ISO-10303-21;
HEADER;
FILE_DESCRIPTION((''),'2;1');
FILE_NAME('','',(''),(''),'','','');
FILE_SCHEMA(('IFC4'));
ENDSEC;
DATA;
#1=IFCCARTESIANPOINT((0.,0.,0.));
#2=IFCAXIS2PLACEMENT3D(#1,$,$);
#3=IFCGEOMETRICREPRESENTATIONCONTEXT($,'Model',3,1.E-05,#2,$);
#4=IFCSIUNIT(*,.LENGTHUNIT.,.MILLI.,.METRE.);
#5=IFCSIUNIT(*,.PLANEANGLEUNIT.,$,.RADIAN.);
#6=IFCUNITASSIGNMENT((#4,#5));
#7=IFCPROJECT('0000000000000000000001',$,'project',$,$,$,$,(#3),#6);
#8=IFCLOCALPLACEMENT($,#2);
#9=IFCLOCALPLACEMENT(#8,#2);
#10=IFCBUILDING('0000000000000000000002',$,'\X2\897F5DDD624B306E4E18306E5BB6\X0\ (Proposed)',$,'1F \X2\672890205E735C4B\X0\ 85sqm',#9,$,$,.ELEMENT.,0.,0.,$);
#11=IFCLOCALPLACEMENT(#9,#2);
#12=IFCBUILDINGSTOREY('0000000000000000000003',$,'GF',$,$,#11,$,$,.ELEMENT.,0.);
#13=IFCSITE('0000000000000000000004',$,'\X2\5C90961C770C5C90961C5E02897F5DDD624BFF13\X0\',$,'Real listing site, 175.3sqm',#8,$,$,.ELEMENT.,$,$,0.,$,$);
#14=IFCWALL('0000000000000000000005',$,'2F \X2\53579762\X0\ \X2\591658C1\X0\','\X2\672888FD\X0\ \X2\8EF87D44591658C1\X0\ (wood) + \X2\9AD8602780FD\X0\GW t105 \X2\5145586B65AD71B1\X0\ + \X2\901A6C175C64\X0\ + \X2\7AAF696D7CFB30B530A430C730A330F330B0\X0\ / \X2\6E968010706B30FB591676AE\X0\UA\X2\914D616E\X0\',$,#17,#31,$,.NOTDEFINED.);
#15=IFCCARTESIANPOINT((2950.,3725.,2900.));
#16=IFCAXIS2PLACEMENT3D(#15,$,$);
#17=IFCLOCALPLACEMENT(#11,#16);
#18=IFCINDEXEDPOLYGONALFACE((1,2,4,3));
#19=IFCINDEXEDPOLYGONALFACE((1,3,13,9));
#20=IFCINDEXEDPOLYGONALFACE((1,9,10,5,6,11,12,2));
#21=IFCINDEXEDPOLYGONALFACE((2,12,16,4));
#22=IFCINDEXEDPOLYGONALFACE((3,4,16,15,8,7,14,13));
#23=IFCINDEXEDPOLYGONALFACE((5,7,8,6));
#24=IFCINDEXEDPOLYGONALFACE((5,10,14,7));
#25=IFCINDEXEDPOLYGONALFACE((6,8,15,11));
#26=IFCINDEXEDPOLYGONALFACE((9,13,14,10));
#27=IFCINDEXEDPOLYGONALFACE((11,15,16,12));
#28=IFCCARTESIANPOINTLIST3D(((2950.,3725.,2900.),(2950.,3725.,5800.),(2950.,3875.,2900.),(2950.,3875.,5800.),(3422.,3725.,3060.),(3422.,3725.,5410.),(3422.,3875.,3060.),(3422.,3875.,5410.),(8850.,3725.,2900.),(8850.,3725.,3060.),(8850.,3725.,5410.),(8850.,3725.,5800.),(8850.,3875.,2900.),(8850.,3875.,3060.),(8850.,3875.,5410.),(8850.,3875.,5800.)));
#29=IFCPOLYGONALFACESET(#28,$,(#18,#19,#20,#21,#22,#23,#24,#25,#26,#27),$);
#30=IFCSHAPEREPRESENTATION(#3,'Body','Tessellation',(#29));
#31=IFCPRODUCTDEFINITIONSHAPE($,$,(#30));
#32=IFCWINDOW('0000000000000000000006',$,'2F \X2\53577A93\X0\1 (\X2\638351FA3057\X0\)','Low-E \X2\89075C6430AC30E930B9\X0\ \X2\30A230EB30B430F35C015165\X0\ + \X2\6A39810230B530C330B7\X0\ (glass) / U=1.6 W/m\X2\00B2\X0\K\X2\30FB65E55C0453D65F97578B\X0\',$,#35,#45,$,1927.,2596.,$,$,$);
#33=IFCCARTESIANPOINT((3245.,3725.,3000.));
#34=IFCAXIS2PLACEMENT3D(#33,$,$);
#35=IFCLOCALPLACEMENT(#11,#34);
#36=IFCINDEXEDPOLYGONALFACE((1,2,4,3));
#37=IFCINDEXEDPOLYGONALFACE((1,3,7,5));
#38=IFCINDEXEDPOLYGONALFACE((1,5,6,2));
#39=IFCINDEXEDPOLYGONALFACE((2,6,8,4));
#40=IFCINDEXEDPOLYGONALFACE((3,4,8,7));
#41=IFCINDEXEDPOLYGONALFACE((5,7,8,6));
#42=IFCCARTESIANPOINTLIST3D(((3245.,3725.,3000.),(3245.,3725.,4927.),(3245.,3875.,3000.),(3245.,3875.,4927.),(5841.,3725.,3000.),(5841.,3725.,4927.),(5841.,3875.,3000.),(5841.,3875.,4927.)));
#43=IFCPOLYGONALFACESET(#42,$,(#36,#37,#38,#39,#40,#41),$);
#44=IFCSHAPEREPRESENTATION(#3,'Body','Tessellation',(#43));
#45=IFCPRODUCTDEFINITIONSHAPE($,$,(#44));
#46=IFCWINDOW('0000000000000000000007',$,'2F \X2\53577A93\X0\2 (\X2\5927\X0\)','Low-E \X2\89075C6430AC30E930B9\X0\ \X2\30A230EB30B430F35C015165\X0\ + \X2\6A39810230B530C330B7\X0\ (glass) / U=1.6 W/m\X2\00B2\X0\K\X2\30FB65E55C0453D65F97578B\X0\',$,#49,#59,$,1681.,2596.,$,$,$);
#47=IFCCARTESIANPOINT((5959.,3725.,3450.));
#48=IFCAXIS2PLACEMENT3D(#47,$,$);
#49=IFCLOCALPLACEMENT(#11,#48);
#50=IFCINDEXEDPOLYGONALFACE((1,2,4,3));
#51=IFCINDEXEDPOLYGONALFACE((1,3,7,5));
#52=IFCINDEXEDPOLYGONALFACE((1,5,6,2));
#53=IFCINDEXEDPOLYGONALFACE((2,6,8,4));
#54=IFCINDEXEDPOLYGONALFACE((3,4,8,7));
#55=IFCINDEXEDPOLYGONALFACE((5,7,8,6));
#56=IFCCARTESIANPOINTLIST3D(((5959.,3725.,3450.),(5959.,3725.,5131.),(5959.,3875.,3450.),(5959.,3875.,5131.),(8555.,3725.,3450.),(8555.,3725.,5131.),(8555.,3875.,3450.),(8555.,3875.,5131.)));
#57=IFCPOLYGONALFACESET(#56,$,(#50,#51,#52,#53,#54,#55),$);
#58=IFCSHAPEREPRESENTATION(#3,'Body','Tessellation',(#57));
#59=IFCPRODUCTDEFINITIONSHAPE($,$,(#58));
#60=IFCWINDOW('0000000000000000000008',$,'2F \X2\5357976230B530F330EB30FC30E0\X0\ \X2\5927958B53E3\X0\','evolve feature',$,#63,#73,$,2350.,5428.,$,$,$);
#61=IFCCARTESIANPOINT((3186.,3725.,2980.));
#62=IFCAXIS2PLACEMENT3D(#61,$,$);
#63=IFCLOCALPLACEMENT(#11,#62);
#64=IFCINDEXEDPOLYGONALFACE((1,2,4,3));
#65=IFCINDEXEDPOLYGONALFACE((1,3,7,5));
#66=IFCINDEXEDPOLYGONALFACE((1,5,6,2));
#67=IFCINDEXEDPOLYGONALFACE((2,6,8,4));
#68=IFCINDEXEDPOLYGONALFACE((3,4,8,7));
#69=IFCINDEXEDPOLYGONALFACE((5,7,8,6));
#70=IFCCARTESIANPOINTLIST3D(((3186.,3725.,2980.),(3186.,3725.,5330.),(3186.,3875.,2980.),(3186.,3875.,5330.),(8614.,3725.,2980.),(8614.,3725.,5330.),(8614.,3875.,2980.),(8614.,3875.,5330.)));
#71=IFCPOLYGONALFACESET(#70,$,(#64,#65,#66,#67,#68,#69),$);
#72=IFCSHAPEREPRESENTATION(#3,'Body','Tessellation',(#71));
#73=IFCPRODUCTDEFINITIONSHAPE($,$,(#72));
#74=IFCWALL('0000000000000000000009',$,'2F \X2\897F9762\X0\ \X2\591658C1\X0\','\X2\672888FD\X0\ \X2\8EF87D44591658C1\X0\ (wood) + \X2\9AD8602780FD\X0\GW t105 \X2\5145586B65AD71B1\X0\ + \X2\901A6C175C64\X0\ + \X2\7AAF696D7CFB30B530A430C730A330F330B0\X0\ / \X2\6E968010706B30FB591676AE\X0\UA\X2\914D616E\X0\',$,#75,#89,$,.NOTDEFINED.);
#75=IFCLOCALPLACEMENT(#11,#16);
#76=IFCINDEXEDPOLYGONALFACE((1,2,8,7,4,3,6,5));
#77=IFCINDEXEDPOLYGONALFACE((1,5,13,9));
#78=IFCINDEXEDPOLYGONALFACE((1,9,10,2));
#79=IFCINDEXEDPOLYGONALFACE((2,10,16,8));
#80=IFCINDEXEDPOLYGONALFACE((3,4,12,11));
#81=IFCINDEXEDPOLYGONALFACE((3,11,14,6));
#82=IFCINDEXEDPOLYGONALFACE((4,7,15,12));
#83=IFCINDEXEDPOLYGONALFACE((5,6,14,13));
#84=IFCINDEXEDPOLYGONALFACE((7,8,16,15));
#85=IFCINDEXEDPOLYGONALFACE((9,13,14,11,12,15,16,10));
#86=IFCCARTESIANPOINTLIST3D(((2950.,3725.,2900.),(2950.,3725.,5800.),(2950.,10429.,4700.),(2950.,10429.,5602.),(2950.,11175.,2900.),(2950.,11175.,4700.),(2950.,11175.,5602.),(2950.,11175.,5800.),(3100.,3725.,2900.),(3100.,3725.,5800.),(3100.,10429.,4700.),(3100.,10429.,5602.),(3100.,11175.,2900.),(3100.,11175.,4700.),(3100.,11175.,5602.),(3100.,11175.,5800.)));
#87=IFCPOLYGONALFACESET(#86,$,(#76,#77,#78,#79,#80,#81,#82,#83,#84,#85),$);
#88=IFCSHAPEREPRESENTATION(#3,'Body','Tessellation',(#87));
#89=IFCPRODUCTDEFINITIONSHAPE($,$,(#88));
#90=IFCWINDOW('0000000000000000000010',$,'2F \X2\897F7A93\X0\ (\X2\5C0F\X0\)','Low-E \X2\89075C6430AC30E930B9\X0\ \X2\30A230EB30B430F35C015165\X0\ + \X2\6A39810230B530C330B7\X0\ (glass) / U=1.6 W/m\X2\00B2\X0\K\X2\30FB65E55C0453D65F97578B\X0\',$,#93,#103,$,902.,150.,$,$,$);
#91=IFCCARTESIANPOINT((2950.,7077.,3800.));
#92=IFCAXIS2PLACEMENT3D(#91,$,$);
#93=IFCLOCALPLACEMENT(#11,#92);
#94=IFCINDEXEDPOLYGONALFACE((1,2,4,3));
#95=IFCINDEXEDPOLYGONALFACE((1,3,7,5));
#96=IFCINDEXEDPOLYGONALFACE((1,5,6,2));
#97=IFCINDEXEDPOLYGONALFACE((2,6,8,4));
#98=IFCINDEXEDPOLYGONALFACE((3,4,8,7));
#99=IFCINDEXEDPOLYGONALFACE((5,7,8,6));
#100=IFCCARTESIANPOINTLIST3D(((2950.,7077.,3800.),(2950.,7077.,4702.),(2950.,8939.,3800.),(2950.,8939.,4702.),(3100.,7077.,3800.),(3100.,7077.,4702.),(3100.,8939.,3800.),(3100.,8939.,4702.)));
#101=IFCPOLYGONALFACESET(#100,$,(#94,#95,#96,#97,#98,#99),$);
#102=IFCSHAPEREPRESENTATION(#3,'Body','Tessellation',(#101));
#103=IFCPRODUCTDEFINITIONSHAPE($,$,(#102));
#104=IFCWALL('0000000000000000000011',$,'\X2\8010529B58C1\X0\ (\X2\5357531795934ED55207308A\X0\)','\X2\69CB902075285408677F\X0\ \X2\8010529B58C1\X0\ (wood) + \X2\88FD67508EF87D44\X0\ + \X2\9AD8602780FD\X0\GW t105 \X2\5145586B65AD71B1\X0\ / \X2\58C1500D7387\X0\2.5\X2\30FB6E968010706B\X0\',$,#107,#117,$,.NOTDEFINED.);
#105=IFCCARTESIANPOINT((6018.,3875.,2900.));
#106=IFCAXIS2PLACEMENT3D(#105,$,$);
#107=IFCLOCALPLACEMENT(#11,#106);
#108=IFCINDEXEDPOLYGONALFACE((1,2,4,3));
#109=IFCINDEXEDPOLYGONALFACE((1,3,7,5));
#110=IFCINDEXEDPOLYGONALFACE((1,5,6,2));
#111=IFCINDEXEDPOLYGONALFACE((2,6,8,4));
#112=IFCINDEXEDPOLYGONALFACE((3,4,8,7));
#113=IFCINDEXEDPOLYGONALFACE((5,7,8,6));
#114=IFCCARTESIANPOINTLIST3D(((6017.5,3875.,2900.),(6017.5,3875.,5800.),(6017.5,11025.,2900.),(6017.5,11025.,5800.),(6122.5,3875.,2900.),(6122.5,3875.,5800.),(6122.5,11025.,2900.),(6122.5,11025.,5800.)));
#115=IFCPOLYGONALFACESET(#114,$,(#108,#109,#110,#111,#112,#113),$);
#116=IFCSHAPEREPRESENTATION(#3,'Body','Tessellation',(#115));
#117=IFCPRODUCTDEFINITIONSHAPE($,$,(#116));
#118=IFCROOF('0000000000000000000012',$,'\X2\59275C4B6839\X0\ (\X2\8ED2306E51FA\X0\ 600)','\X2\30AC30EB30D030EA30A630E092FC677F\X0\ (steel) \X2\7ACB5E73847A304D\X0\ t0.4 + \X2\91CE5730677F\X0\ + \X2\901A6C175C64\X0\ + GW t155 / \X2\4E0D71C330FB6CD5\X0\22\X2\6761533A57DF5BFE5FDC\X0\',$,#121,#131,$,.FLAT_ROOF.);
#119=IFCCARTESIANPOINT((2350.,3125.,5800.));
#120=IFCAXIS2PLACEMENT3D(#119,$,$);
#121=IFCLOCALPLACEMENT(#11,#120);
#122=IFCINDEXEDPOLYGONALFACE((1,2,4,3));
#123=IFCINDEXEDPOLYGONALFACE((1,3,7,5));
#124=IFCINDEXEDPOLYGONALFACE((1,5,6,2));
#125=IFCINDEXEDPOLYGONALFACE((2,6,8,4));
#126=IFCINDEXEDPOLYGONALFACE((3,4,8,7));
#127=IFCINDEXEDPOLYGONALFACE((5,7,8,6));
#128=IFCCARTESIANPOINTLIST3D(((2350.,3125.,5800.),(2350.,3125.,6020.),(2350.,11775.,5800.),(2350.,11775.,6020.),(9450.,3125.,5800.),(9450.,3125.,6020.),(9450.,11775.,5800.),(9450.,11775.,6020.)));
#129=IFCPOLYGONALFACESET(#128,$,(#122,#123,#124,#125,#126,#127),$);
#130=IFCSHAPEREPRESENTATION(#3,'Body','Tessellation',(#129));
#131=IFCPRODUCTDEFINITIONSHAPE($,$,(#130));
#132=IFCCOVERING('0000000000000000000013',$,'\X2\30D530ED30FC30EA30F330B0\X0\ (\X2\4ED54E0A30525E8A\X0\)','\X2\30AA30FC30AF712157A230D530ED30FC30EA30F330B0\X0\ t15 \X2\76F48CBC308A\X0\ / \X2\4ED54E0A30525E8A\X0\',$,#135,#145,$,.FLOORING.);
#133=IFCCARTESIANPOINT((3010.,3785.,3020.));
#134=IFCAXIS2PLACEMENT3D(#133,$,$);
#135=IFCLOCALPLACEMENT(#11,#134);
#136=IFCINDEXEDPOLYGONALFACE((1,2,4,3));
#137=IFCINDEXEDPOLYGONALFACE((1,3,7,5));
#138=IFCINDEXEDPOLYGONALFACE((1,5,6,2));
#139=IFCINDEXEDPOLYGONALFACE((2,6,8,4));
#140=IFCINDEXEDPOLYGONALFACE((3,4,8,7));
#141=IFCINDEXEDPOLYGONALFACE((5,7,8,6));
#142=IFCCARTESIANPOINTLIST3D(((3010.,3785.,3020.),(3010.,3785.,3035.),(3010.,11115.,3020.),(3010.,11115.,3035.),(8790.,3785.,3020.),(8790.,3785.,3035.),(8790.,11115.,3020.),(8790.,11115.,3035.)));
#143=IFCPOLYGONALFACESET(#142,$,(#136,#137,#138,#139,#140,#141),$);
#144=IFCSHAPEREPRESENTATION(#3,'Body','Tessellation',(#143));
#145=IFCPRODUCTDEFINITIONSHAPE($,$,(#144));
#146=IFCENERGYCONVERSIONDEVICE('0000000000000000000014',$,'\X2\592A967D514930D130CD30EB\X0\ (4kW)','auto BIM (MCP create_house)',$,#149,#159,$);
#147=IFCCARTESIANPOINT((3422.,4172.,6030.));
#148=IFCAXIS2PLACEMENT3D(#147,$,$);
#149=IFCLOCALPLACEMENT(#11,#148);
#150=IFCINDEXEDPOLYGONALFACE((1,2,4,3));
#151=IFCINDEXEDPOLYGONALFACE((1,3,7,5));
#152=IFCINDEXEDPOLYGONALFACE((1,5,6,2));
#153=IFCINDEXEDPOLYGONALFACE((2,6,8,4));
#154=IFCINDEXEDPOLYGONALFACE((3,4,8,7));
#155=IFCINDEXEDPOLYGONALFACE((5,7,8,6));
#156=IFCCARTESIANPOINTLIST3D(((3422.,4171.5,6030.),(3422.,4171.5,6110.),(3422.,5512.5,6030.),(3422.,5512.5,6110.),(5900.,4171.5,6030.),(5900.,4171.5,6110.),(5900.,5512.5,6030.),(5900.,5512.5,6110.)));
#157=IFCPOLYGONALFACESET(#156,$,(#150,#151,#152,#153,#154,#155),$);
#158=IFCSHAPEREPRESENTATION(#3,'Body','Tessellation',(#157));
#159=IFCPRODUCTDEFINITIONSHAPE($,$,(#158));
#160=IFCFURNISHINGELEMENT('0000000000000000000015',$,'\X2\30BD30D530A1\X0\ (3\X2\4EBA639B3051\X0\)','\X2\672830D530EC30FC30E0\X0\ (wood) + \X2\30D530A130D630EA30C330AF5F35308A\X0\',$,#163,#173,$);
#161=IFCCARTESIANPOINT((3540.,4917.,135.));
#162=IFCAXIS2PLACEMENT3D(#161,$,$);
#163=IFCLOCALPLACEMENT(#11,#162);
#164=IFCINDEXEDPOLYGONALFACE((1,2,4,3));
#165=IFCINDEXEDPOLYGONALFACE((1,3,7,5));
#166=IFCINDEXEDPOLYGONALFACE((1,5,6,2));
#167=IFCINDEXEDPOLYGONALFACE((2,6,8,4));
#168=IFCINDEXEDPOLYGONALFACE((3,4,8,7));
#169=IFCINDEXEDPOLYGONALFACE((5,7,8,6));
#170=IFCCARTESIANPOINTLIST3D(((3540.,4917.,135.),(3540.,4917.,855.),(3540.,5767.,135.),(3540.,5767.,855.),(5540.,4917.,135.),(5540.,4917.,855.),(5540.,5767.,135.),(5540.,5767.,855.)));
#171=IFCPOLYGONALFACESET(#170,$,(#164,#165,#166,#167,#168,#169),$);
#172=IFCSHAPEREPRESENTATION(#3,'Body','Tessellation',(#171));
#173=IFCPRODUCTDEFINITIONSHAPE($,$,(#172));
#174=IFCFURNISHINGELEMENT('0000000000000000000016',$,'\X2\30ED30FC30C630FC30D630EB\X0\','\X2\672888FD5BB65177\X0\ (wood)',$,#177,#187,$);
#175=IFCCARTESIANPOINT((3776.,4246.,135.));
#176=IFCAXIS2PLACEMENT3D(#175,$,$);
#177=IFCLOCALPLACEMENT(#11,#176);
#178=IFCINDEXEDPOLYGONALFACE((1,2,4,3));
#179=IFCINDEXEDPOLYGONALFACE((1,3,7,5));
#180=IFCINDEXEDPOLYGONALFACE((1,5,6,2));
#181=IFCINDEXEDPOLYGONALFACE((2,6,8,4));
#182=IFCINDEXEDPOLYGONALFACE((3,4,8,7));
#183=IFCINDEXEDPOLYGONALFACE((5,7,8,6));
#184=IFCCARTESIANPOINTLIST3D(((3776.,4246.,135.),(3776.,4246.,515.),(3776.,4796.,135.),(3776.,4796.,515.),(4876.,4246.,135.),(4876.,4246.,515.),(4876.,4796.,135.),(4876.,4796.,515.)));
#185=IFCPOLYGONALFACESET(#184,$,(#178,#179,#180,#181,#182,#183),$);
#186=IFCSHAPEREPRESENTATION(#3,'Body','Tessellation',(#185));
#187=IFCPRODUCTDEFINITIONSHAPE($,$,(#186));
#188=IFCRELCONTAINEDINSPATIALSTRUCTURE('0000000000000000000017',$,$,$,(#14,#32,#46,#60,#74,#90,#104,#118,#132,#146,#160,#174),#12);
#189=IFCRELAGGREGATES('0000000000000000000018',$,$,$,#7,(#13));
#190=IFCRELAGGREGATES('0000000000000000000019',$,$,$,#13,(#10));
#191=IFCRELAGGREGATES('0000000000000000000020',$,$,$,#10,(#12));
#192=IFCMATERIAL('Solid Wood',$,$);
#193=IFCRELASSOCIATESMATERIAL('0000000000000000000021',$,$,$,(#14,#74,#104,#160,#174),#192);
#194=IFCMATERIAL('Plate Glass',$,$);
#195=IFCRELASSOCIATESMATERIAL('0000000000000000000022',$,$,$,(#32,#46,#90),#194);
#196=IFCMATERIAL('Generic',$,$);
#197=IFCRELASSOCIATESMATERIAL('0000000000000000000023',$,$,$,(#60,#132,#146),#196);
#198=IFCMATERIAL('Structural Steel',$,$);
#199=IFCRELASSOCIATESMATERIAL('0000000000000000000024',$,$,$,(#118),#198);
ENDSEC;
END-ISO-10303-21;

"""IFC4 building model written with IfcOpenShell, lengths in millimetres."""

from ifc_helpers import new_model, si_unit, frame, frame_2d, origin, place, context, project, spatial, rectangle, extrude, material, element, fill, save


model = new_model("IFC4")

# Units and contexts
model_context = context("Model", 3, precision=1e-05, world=origin())
ifc_project = project(units=[si_unit("LENGTHUNIT", "METRE", prefix="MILLI"), si_unit("PLANEANGLEUNIT", "RADIAN")], contexts=[model_context])

# Site, building, storey
site_placement = place(None, origin())
site = spatial("IfcSite", under=ifc_project, at=site_placement, Name="岐阜県岐阜市西川手３", ObjectType="Real listing site, 175.3sqm", CompositionType="ELEMENT", RefElevation=0.0)
building_placement = place(site_placement, origin())
building = spatial("IfcBuilding", under=site, at=building_placement, Name="西川手の丘の家 (Proposed)", ObjectType="1F 木造平屋 85sqm", CompositionType="ELEMENT", ElevationOfRefHeight=0.0, ElevationOfTerrain=0.0)
storey_placement = place(building_placement, origin())
storey = spatial("IfcBuildingStorey", under=building, at=storey_placement, Name="GF", CompositionType="ELEMENT", Elevation=0.0)

# Shared definitions
ifc_material_1 = material(Name="Solid Wood")

# Wall, openings, windows
wall_1_placement = place(storey_placement, frame((2950.0, 3725.0, 2900.0)))
wall_1 = element("IfcWall", 1, at=wall_1_placement, inside=storey, material=ifc_material_1, Name="2F 南面 外壁", Description="木製 軸組外壁 (wood) + 高性能GW t105 充填断熱 + 通気層 + 窯業系サイディング / 準耐火・外皮UA配慮", PredefinedType="NOTDEFINED", context=model_context, shape_type="SweptSolid", body=[
    extrude(rectangle(XDim=5900.0, YDim=150.0, at=frame_2d((2950.0, 75.0))), frame((2950.0, 3725.0, 2900.0)), (0.0, 0.0, 1.0), 2900.0),
])
opening_1_placement = place(storey_placement, frame((3245.0, 3725.0, 3000.0)))
opening_1 = element("IfcOpeningElement", 2, at=opening_1_placement, cuts=wall_1, PredefinedType="NOTDEFINED", context=model_context, shape_type="SweptSolid", body=[
    extrude(rectangle(XDim=2596.0, YDim=150.0, at=frame_2d((1298.0, 75.0))), frame((3245.0, 3725.0, 3000.0)), (0.0, 0.0, 1.0), 1927.0),
])
opening_2_placement = place(storey_placement, frame((5959.0, 3725.0, 3450.0)))
opening_2 = element("IfcOpeningElement", 3, at=opening_2_placement, cuts=wall_1, PredefinedType="NOTDEFINED", context=model_context, shape_type="SweptSolid", body=[
    extrude(rectangle(XDim=2596.0, YDim=150.0, at=frame_2d((1298.0, 75.0))), frame((5959.0, 3725.0, 3450.0)), (0.0, 0.0, 1.0), 1681.0),
])
opening_3_placement = place(storey_placement, frame((3186.0, 3725.0, 2980.0)))
opening_3 = element("IfcOpeningElement", 4, at=opening_3_placement, cuts=wall_1, PredefinedType="NOTDEFINED", context=model_context, shape_type="SweptSolid", body=[
    extrude(rectangle(XDim=5428.0, YDim=150.0, at=frame_2d((2714.0, 75.0))), frame((3186.0, 3725.0, 2980.0)), (0.0, 0.0, 1.0), 2350.0),
])
ifc_material_2 = material(Name="Plate Glass")
window_1_placement = place(storey_placement, frame((3245.0, 3725.0, 3000.0)))
window_1 = element("IfcWindow", 5, at=window_1_placement, inside=storey, material=ifc_material_2, Name="2F 南窓1 (掃出し)", Description="Low-E 複層ガラス アルゴン封入 + 樹脂サッシ (glass) / U=1.6 W/m²K・日射取得型", OverallHeight=1927.0, OverallWidth=2596.0, context=model_context, shape_type="SweptSolid", body=[
    extrude(rectangle(XDim=2596.0, YDim=150.0, at=frame_2d((1298.0, 75.0))), frame((3245.0, 3725.0, 3000.0)), (0.0, 0.0, 1.0), 1927.0),
])
fill(opening_1, window_1)
window_2_placement = place(storey_placement, frame((5959.0, 3725.0, 3450.0)))
window_2 = element("IfcWindow", 6, at=window_2_placement, inside=storey, material=ifc_material_2, Name="2F 南窓2 (大)", Description="Low-E 複層ガラス アルゴン封入 + 樹脂サッシ (glass) / U=1.6 W/m²K・日射取得型", OverallHeight=1681.0, OverallWidth=2596.0, context=model_context, shape_type="SweptSolid", body=[
    extrude(rectangle(XDim=2596.0, YDim=150.0, at=frame_2d((1298.0, 75.0))), frame((5959.0, 3725.0, 3450.0)), (0.0, 0.0, 1.0), 1681.0),
])
fill(opening_2, window_2)
ifc_material_3 = material(Name="Generic")
window_3_placement = place(storey_placement, frame((3186.0, 3725.0, 2980.0)))
window_3 = element("IfcWindow", 7, at=window_3_placement, inside=storey, material=ifc_material_3, Name="2F 南面サンルーム 大開口", Description="evolve feature", OverallHeight=2350.0, OverallWidth=5428.0, context=model_context, shape_type="SweptSolid", body=[
    extrude(rectangle(XDim=5428.0, YDim=150.0, at=frame_2d((2714.0, 75.0))), frame((3186.0, 3725.0, 2980.0)), (0.0, 0.0, 1.0), 2350.0),
])
fill(opening_3, window_3)

# Wall, opening, window
wall_2_placement = place(storey_placement, frame((2950.0, 3725.0, 2900.0)))
wall_2 = element("IfcWall", 8, at=wall_2_placement, inside=storey, material=ifc_material_1, Name="2F 西面 外壁", Description="木製 軸組外壁 (wood) + 高性能GW t105 充填断熱 + 通気層 + 窯業系サイディング / 準耐火・外皮UA配慮", PredefinedType="NOTDEFINED", context=model_context, shape_type="SweptSolid", body=[
    extrude(rectangle(XDim=150.0, YDim=7450.0, at=frame_2d((75.0, 3725.0))), frame((2950.0, 3725.0, 2900.0)), (0.0, 0.0, 1.0), 2900.0),
])
opening_4_placement = place(storey_placement, frame((2950.0, 7077.0, 3800.0)))
opening_4 = element("IfcOpeningElement", 9, at=opening_4_placement, cuts=wall_2, PredefinedType="NOTDEFINED", context=model_context, shape_type="SweptSolid", body=[
    extrude(rectangle(XDim=150.0, YDim=1862.0, at=frame_2d((75.0, 931.0))), frame((2950.0, 7077.0, 3800.0)), (0.0, 0.0, 1.0), 902.0),
])
window_4_placement = place(storey_placement, frame((2950.0, 7077.0, 3800.0)))
window_4 = element("IfcWindow", 10, at=window_4_placement, inside=storey, material=ifc_material_2, Name="2F 西窓 (小)", Description="Low-E 複層ガラス アルゴン封入 + 樹脂サッシ (glass) / U=1.6 W/m²K・日射取得型", OverallHeight=902.0, OverallWidth=150.0, context=model_context, shape_type="SweptSolid", body=[
    extrude(rectangle(XDim=150.0, YDim=1862.0, at=frame_2d((75.0, 931.0))), frame((2950.0, 7077.0, 3800.0)), (0.0, 0.0, 1.0), 902.0),
])
fill(opening_4, window_4)

# Wall
wall_3_placement = place(storey_placement, frame((6018.0, 3875.0, 2900.0)))
element("IfcWall", 11, at=wall_3_placement, inside=storey, material=ifc_material_1, Name="耐力壁 (南北間仕切り)", Description="構造用合板 耐力壁 (wood) + 製材軸組 + 高性能GW t105 充填断熱 / 壁倍率2.5・準耐火", PredefinedType="NOTDEFINED", context=model_context, shape_type="SweptSolid", body=[
    extrude(rectangle(XDim=105.0, YDim=7150.0, at=frame_2d((52.0, 3575.0))), frame((6018.0, 3875.0, 2900.0)), (0.0, 0.0, 1.0), 2900.0),
])

# Roof
ifc_material_4 = material(Name="Structural Steel")
roof_placement = place(storey_placement, frame((2350.0, 3125.0, 5800.0)))
element("IfcRoof", 12, at=roof_placement, inside=storey, material=ifc_material_4, Name="大屋根 (軒の出 600)", Description="ガルバリウム鋼板 (steel) 立平葺き t0.4 + 野地板 + 通気層 + GW t155 / 不燃・法22条区域対応", PredefinedType="FLAT_ROOF", context=model_context, shape_type="SweptSolid", body=[
    extrude(rectangle(XDim=7100.0, YDim=8650.0, at=frame_2d((3550.0, 4325.0))), frame((2350.0, 3125.0, 5800.0)), (0.0, 0.0, 1.0), 220.0),
])

# Covering
covering_placement = place(storey_placement, frame((3010.0, 3785.0, 3020.0)))
element("IfcCovering", 13, at=covering_placement, inside=storey, material=ifc_material_3, Name="フローリング (仕上げ床)", Description="オーク無垢フローリング t15 直貼り / 仕上げ床", PredefinedType="FLOORING", context=model_context, shape_type="SweptSolid", body=[
    extrude(rectangle(XDim=5780.0, YDim=7330.0, at=frame_2d((2890.0, 3665.0))), frame((3010.0, 3785.0, 3020.0)), (0.0, 0.0, 1.0), 15.0),
])

# Energy conversion device
energy_conversion_device_placement = place(storey_placement, frame((3422.0, 4172.0, 6030.0)))
element("IfcEnergyConversionDevice", 14, at=energy_conversion_device_placement, inside=storey, material=ifc_material_3, Name="太陽光パネル (4kW)", Description="auto BIM (MCP create_house)", context=model_context, shape_type="SweptSolid", body=[
    extrude(rectangle(XDim=2478.0, YDim=1341.0, at=frame_2d((1239.0, 670.0))), frame((3422.0, 4172.0, 6030.0)), (0.0, 0.0, 1.0), 80.0),
])

# Furnishing elements
furnishing_1_placement = place(storey_placement, frame((3540.0, 4917.0, 135.0)))
element("IfcFurnishingElement", 15, at=furnishing_1_placement, inside=storey, material=ifc_material_1, Name="ソファ (3人掛け)", Description="木フレーム (wood) + ファブリック張り", context=model_context, shape_type="SweptSolid", body=[
    extrude(rectangle(XDim=2000.0, YDim=850.0, at=frame_2d((1000.0, 425.0))), frame((3540.0, 4917.0, 135.0)), (0.0, 0.0, 1.0), 720.0),
])
furnishing_2_placement = place(storey_placement, frame((3776.0, 4246.0, 135.0)))
element("IfcFurnishingElement", 16, at=furnishing_2_placement, inside=storey, material=ifc_material_1, Name="ローテーブル", Description="木製家具 (wood)", context=model_context, shape_type="SweptSolid", body=[
    extrude(rectangle(XDim=1100.0, YDim=550.0, at=frame_2d((550.0, 275.0))), frame((3776.0, 4246.0, 135.0)), (0.0, 0.0, 1.0), 380.0),
])

save(model, "model.ifc")
